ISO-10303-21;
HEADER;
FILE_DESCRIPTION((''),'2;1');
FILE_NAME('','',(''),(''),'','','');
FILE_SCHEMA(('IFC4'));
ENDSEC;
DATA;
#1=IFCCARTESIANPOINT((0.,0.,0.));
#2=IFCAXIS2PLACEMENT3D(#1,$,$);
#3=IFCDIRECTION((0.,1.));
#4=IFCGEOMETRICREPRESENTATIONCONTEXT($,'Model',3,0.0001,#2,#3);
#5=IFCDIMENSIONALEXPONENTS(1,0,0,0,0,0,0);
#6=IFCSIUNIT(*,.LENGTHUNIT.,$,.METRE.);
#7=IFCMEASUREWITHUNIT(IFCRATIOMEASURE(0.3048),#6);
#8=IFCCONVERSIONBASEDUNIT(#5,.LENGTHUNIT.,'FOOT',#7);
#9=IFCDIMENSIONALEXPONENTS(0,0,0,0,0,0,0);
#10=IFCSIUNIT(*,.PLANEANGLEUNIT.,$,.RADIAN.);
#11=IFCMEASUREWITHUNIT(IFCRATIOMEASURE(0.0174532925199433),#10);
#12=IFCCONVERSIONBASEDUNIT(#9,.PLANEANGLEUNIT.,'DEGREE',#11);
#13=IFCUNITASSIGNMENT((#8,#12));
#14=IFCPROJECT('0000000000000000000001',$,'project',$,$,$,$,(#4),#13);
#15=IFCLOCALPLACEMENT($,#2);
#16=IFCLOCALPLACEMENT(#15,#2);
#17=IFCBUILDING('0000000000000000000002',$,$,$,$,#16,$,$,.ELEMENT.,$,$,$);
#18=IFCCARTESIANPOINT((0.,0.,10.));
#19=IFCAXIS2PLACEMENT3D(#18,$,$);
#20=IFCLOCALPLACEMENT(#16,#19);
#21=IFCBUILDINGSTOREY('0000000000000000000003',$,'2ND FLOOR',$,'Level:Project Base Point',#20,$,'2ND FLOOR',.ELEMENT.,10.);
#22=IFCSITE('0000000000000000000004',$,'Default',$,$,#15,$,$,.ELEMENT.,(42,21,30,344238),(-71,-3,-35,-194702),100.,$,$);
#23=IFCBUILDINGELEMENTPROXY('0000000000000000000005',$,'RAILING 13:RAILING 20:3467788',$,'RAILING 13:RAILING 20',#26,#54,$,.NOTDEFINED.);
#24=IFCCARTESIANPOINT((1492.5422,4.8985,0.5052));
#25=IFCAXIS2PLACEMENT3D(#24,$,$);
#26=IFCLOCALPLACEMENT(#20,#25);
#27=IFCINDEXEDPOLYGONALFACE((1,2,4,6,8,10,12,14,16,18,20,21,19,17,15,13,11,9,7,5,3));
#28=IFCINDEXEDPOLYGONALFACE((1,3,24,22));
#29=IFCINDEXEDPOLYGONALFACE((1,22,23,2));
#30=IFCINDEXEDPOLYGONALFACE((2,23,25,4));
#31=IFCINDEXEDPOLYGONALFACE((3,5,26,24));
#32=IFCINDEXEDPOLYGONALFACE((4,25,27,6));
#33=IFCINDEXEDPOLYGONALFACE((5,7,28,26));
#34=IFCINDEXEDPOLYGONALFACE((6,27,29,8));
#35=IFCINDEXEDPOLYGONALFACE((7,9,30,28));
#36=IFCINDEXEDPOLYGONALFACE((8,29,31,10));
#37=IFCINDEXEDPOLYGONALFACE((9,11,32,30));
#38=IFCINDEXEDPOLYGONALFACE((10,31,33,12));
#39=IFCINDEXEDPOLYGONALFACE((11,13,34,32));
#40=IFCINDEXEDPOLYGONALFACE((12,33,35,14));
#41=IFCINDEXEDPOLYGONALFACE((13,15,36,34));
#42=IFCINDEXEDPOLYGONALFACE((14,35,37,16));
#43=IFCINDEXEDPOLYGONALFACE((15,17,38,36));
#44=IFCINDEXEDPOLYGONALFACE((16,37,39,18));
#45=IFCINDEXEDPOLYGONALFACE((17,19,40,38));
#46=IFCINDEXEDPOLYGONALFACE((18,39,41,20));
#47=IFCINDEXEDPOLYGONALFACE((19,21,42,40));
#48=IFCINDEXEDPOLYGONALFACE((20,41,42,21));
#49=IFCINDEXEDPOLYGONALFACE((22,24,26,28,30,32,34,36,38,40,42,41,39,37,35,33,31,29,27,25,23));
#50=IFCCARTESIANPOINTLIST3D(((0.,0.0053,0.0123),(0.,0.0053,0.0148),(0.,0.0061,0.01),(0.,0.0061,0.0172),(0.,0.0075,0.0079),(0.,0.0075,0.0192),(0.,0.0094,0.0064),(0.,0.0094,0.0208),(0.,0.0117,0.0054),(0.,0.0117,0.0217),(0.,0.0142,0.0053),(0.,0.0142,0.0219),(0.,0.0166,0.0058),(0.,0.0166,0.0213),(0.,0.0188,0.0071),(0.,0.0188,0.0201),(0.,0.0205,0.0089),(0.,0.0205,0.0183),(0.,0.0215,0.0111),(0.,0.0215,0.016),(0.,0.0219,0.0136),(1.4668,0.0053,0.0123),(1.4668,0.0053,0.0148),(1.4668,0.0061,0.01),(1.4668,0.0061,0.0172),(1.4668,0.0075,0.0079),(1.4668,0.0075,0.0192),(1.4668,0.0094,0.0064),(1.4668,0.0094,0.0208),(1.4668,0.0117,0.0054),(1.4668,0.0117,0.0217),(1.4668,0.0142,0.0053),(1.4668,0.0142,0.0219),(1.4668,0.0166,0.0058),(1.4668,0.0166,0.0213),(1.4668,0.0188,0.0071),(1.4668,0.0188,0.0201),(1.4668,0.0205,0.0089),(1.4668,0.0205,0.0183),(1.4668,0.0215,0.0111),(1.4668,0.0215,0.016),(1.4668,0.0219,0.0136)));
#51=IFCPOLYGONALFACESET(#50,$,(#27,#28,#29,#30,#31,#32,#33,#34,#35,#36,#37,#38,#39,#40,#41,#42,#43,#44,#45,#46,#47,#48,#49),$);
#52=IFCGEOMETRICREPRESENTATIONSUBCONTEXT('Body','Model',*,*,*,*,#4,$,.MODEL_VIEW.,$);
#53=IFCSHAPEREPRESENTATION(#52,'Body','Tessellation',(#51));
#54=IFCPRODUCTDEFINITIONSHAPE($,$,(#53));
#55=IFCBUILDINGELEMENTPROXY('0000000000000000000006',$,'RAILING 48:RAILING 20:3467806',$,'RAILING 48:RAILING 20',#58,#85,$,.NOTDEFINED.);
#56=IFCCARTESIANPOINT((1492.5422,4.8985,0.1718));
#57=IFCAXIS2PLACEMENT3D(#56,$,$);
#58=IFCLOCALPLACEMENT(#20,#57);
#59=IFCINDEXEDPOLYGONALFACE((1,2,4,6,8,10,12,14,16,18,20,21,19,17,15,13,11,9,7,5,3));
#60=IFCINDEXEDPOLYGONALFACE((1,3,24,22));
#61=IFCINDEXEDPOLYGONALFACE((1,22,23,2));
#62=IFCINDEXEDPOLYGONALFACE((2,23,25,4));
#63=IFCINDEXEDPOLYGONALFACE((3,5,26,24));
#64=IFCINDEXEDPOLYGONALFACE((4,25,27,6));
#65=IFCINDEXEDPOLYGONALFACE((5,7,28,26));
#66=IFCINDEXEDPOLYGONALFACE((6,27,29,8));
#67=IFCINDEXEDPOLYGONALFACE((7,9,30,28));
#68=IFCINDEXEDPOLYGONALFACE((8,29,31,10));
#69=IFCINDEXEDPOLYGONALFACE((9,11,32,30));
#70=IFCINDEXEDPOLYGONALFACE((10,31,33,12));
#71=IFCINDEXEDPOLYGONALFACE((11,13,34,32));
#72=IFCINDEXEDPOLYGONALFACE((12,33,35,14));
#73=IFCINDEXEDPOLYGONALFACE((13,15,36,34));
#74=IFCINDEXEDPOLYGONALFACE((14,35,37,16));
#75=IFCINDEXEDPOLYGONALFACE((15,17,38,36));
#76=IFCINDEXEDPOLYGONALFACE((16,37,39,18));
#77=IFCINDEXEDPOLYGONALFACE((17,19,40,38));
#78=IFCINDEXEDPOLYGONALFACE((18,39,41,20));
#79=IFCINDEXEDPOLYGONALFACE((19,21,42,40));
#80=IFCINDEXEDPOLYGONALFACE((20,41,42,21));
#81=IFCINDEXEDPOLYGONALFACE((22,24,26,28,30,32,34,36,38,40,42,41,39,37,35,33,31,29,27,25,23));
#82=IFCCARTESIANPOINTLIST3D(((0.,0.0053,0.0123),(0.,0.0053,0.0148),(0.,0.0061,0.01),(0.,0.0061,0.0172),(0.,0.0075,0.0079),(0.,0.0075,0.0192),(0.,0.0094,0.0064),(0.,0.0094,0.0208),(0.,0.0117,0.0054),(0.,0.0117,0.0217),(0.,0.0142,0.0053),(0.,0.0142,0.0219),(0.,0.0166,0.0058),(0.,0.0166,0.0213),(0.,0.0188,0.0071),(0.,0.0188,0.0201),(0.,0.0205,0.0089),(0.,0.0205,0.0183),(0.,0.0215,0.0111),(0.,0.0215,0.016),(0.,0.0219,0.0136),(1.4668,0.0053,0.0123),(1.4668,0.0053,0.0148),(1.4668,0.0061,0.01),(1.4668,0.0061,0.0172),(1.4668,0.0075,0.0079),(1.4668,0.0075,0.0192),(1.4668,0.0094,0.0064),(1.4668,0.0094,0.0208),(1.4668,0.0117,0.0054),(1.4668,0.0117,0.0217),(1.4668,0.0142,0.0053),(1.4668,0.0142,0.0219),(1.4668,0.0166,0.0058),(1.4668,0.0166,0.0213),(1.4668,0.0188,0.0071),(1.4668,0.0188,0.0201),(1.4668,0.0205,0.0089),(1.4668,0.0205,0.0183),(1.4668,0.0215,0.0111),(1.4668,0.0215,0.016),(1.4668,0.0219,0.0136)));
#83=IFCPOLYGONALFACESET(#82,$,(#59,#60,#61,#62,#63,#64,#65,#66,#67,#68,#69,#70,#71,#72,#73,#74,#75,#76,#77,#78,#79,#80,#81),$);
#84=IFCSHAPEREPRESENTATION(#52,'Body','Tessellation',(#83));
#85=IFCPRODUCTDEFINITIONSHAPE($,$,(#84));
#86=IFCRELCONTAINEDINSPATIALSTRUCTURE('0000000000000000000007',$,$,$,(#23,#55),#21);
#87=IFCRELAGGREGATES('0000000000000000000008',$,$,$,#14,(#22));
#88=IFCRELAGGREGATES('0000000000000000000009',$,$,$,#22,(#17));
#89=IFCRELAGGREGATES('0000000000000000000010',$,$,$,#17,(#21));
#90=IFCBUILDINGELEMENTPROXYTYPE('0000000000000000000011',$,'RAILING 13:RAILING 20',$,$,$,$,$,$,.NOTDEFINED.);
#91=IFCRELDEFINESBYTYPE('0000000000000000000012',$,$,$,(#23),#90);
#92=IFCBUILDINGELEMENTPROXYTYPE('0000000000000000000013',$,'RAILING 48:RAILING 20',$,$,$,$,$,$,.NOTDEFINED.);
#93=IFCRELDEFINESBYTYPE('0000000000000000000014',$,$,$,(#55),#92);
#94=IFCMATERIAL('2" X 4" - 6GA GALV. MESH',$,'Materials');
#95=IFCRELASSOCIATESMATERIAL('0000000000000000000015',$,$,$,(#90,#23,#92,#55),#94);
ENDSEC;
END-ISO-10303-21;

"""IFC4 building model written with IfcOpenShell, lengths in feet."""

from ifc_helpers import new_model, entity, si_unit, converted_unit, direction, frame, origin, origin_2d_with_axis, place, context, subcontext, project, spatial, circle, extrude, source, transform, mapped, material, type_object, type_shapes, element, save


model = new_model("IFC4")

# Units and contexts
model_context = context("Model", 3, precision=0.0001, world=origin(), true_north=direction((0.0, 1.0)))
body_context = subcontext(model_context, "Body", "Model", "MODEL_VIEW")
ifc_project = project(units=[converted_unit("LENGTHUNIT", "FOOT", entity("IfcRatioMeasure", 0.3048), si_unit("LENGTHUNIT", "METRE"), dimensions=[1, 0, 0, 0, 0, 0, 0]), converted_unit("PLANEANGLEUNIT", "DEGREE", entity("IfcRatioMeasure", 0.0174532925199433), si_unit("PLANEANGLEUNIT", "RADIAN"), dimensions=[0, 0, 0, 0, 0, 0, 0])], contexts=[model_context])

# Site, building, storey
site_placement = place(None, origin())
site = spatial("IfcSite", under=ifc_project, at=site_placement, Name="Default", CompositionType="ELEMENT", RefLatitude=(42, 21, 30, 344238), RefLongitude=(-71, -3, -35, -194702), RefElevation=100.0)
building_placement = place(site_placement, origin())
building = spatial("IfcBuilding", under=site, at=building_placement, CompositionType="ELEMENT")
storey_placement = place(building_placement, frame((0.0, 0.0, 10.0)))
storey = spatial("IfcBuildingStorey", under=building, at=storey_placement, Name="2ND FLOOR", ObjectType="Level:Project Base Point", LongName="2ND FLOOR", CompositionType="ELEMENT", Elevation=10.0)

# Building element proxies
ifc_material_1 = material(Name="2\" X 4\" - 6GA GALV. MESH", Category="Materials")
building_element_proxy_type_1 = type_object("IfcBuildingElementProxyType", Name="RAILING 13:RAILING 20", PredefinedType="NOTDEFINED", material=ifc_material_1)
shared_shape_1 = source(origin(), body_context, "Body", "SweptSolid", [
    extrude(circle(Radius=0.0083, at=origin_2d_with_axis()), frame((0.0, 0.0136, 0.0136), z_axis=(1.0, 0.0, 0.0), x_axis=(0.0, 1.0, 0.0)), (0.0, 0.0, 1.0), 1.4668),
])
type_shapes(building_element_proxy_type_1, [shared_shape_1])
proxy_1_placement = place(storey_placement, frame((1492.5422, 4.8985, 0.5052)))
element("IfcBuildingElementProxy", 1, at=proxy_1_placement, inside=storey, type_object=building_element_proxy_type_1, material=ifc_material_1, Name="RAILING 13:RAILING 20:3467788", ObjectType="RAILING 13:RAILING 20", PredefinedType="NOTDEFINED", context=body_context, shape_type="MappedRepresentation", body=[
    mapped(shared_shape_1, transform((0.0, 0.0, 0.0), scale=1.0)),
])
building_element_proxy_type_2 = type_object("IfcBuildingElementProxyType", Name="RAILING 48:RAILING 20", PredefinedType="NOTDEFINED", material=ifc_material_1)
shared_shape_2 = source(origin(), body_context, "Body", "SweptSolid", [
    extrude(circle(Radius=0.0083, at=origin_2d_with_axis()), frame((0.0, 0.0136, 0.0136), z_axis=(1.0, 0.0, 0.0), x_axis=(0.0, 1.0, 0.0)), (0.0, 0.0, 1.0), 1.4668),
])
type_shapes(building_element_proxy_type_2, [shared_shape_2])
proxy_2_placement = place(storey_placement, frame((1492.5422, 4.8985, 0.1718)))
element("IfcBuildingElementProxy", 2, at=proxy_2_placement, inside=storey, type_object=building_element_proxy_type_2, material=ifc_material_1, Name="RAILING 48:RAILING 20:3467806", ObjectType="RAILING 48:RAILING 20", PredefinedType="NOTDEFINED", context=body_context, shape_type="MappedRepresentation", body=[
    mapped(shared_shape_2, transform((0.0, 0.0, 0.0), scale=1.0)),
])

save(model, "model.ifc")
